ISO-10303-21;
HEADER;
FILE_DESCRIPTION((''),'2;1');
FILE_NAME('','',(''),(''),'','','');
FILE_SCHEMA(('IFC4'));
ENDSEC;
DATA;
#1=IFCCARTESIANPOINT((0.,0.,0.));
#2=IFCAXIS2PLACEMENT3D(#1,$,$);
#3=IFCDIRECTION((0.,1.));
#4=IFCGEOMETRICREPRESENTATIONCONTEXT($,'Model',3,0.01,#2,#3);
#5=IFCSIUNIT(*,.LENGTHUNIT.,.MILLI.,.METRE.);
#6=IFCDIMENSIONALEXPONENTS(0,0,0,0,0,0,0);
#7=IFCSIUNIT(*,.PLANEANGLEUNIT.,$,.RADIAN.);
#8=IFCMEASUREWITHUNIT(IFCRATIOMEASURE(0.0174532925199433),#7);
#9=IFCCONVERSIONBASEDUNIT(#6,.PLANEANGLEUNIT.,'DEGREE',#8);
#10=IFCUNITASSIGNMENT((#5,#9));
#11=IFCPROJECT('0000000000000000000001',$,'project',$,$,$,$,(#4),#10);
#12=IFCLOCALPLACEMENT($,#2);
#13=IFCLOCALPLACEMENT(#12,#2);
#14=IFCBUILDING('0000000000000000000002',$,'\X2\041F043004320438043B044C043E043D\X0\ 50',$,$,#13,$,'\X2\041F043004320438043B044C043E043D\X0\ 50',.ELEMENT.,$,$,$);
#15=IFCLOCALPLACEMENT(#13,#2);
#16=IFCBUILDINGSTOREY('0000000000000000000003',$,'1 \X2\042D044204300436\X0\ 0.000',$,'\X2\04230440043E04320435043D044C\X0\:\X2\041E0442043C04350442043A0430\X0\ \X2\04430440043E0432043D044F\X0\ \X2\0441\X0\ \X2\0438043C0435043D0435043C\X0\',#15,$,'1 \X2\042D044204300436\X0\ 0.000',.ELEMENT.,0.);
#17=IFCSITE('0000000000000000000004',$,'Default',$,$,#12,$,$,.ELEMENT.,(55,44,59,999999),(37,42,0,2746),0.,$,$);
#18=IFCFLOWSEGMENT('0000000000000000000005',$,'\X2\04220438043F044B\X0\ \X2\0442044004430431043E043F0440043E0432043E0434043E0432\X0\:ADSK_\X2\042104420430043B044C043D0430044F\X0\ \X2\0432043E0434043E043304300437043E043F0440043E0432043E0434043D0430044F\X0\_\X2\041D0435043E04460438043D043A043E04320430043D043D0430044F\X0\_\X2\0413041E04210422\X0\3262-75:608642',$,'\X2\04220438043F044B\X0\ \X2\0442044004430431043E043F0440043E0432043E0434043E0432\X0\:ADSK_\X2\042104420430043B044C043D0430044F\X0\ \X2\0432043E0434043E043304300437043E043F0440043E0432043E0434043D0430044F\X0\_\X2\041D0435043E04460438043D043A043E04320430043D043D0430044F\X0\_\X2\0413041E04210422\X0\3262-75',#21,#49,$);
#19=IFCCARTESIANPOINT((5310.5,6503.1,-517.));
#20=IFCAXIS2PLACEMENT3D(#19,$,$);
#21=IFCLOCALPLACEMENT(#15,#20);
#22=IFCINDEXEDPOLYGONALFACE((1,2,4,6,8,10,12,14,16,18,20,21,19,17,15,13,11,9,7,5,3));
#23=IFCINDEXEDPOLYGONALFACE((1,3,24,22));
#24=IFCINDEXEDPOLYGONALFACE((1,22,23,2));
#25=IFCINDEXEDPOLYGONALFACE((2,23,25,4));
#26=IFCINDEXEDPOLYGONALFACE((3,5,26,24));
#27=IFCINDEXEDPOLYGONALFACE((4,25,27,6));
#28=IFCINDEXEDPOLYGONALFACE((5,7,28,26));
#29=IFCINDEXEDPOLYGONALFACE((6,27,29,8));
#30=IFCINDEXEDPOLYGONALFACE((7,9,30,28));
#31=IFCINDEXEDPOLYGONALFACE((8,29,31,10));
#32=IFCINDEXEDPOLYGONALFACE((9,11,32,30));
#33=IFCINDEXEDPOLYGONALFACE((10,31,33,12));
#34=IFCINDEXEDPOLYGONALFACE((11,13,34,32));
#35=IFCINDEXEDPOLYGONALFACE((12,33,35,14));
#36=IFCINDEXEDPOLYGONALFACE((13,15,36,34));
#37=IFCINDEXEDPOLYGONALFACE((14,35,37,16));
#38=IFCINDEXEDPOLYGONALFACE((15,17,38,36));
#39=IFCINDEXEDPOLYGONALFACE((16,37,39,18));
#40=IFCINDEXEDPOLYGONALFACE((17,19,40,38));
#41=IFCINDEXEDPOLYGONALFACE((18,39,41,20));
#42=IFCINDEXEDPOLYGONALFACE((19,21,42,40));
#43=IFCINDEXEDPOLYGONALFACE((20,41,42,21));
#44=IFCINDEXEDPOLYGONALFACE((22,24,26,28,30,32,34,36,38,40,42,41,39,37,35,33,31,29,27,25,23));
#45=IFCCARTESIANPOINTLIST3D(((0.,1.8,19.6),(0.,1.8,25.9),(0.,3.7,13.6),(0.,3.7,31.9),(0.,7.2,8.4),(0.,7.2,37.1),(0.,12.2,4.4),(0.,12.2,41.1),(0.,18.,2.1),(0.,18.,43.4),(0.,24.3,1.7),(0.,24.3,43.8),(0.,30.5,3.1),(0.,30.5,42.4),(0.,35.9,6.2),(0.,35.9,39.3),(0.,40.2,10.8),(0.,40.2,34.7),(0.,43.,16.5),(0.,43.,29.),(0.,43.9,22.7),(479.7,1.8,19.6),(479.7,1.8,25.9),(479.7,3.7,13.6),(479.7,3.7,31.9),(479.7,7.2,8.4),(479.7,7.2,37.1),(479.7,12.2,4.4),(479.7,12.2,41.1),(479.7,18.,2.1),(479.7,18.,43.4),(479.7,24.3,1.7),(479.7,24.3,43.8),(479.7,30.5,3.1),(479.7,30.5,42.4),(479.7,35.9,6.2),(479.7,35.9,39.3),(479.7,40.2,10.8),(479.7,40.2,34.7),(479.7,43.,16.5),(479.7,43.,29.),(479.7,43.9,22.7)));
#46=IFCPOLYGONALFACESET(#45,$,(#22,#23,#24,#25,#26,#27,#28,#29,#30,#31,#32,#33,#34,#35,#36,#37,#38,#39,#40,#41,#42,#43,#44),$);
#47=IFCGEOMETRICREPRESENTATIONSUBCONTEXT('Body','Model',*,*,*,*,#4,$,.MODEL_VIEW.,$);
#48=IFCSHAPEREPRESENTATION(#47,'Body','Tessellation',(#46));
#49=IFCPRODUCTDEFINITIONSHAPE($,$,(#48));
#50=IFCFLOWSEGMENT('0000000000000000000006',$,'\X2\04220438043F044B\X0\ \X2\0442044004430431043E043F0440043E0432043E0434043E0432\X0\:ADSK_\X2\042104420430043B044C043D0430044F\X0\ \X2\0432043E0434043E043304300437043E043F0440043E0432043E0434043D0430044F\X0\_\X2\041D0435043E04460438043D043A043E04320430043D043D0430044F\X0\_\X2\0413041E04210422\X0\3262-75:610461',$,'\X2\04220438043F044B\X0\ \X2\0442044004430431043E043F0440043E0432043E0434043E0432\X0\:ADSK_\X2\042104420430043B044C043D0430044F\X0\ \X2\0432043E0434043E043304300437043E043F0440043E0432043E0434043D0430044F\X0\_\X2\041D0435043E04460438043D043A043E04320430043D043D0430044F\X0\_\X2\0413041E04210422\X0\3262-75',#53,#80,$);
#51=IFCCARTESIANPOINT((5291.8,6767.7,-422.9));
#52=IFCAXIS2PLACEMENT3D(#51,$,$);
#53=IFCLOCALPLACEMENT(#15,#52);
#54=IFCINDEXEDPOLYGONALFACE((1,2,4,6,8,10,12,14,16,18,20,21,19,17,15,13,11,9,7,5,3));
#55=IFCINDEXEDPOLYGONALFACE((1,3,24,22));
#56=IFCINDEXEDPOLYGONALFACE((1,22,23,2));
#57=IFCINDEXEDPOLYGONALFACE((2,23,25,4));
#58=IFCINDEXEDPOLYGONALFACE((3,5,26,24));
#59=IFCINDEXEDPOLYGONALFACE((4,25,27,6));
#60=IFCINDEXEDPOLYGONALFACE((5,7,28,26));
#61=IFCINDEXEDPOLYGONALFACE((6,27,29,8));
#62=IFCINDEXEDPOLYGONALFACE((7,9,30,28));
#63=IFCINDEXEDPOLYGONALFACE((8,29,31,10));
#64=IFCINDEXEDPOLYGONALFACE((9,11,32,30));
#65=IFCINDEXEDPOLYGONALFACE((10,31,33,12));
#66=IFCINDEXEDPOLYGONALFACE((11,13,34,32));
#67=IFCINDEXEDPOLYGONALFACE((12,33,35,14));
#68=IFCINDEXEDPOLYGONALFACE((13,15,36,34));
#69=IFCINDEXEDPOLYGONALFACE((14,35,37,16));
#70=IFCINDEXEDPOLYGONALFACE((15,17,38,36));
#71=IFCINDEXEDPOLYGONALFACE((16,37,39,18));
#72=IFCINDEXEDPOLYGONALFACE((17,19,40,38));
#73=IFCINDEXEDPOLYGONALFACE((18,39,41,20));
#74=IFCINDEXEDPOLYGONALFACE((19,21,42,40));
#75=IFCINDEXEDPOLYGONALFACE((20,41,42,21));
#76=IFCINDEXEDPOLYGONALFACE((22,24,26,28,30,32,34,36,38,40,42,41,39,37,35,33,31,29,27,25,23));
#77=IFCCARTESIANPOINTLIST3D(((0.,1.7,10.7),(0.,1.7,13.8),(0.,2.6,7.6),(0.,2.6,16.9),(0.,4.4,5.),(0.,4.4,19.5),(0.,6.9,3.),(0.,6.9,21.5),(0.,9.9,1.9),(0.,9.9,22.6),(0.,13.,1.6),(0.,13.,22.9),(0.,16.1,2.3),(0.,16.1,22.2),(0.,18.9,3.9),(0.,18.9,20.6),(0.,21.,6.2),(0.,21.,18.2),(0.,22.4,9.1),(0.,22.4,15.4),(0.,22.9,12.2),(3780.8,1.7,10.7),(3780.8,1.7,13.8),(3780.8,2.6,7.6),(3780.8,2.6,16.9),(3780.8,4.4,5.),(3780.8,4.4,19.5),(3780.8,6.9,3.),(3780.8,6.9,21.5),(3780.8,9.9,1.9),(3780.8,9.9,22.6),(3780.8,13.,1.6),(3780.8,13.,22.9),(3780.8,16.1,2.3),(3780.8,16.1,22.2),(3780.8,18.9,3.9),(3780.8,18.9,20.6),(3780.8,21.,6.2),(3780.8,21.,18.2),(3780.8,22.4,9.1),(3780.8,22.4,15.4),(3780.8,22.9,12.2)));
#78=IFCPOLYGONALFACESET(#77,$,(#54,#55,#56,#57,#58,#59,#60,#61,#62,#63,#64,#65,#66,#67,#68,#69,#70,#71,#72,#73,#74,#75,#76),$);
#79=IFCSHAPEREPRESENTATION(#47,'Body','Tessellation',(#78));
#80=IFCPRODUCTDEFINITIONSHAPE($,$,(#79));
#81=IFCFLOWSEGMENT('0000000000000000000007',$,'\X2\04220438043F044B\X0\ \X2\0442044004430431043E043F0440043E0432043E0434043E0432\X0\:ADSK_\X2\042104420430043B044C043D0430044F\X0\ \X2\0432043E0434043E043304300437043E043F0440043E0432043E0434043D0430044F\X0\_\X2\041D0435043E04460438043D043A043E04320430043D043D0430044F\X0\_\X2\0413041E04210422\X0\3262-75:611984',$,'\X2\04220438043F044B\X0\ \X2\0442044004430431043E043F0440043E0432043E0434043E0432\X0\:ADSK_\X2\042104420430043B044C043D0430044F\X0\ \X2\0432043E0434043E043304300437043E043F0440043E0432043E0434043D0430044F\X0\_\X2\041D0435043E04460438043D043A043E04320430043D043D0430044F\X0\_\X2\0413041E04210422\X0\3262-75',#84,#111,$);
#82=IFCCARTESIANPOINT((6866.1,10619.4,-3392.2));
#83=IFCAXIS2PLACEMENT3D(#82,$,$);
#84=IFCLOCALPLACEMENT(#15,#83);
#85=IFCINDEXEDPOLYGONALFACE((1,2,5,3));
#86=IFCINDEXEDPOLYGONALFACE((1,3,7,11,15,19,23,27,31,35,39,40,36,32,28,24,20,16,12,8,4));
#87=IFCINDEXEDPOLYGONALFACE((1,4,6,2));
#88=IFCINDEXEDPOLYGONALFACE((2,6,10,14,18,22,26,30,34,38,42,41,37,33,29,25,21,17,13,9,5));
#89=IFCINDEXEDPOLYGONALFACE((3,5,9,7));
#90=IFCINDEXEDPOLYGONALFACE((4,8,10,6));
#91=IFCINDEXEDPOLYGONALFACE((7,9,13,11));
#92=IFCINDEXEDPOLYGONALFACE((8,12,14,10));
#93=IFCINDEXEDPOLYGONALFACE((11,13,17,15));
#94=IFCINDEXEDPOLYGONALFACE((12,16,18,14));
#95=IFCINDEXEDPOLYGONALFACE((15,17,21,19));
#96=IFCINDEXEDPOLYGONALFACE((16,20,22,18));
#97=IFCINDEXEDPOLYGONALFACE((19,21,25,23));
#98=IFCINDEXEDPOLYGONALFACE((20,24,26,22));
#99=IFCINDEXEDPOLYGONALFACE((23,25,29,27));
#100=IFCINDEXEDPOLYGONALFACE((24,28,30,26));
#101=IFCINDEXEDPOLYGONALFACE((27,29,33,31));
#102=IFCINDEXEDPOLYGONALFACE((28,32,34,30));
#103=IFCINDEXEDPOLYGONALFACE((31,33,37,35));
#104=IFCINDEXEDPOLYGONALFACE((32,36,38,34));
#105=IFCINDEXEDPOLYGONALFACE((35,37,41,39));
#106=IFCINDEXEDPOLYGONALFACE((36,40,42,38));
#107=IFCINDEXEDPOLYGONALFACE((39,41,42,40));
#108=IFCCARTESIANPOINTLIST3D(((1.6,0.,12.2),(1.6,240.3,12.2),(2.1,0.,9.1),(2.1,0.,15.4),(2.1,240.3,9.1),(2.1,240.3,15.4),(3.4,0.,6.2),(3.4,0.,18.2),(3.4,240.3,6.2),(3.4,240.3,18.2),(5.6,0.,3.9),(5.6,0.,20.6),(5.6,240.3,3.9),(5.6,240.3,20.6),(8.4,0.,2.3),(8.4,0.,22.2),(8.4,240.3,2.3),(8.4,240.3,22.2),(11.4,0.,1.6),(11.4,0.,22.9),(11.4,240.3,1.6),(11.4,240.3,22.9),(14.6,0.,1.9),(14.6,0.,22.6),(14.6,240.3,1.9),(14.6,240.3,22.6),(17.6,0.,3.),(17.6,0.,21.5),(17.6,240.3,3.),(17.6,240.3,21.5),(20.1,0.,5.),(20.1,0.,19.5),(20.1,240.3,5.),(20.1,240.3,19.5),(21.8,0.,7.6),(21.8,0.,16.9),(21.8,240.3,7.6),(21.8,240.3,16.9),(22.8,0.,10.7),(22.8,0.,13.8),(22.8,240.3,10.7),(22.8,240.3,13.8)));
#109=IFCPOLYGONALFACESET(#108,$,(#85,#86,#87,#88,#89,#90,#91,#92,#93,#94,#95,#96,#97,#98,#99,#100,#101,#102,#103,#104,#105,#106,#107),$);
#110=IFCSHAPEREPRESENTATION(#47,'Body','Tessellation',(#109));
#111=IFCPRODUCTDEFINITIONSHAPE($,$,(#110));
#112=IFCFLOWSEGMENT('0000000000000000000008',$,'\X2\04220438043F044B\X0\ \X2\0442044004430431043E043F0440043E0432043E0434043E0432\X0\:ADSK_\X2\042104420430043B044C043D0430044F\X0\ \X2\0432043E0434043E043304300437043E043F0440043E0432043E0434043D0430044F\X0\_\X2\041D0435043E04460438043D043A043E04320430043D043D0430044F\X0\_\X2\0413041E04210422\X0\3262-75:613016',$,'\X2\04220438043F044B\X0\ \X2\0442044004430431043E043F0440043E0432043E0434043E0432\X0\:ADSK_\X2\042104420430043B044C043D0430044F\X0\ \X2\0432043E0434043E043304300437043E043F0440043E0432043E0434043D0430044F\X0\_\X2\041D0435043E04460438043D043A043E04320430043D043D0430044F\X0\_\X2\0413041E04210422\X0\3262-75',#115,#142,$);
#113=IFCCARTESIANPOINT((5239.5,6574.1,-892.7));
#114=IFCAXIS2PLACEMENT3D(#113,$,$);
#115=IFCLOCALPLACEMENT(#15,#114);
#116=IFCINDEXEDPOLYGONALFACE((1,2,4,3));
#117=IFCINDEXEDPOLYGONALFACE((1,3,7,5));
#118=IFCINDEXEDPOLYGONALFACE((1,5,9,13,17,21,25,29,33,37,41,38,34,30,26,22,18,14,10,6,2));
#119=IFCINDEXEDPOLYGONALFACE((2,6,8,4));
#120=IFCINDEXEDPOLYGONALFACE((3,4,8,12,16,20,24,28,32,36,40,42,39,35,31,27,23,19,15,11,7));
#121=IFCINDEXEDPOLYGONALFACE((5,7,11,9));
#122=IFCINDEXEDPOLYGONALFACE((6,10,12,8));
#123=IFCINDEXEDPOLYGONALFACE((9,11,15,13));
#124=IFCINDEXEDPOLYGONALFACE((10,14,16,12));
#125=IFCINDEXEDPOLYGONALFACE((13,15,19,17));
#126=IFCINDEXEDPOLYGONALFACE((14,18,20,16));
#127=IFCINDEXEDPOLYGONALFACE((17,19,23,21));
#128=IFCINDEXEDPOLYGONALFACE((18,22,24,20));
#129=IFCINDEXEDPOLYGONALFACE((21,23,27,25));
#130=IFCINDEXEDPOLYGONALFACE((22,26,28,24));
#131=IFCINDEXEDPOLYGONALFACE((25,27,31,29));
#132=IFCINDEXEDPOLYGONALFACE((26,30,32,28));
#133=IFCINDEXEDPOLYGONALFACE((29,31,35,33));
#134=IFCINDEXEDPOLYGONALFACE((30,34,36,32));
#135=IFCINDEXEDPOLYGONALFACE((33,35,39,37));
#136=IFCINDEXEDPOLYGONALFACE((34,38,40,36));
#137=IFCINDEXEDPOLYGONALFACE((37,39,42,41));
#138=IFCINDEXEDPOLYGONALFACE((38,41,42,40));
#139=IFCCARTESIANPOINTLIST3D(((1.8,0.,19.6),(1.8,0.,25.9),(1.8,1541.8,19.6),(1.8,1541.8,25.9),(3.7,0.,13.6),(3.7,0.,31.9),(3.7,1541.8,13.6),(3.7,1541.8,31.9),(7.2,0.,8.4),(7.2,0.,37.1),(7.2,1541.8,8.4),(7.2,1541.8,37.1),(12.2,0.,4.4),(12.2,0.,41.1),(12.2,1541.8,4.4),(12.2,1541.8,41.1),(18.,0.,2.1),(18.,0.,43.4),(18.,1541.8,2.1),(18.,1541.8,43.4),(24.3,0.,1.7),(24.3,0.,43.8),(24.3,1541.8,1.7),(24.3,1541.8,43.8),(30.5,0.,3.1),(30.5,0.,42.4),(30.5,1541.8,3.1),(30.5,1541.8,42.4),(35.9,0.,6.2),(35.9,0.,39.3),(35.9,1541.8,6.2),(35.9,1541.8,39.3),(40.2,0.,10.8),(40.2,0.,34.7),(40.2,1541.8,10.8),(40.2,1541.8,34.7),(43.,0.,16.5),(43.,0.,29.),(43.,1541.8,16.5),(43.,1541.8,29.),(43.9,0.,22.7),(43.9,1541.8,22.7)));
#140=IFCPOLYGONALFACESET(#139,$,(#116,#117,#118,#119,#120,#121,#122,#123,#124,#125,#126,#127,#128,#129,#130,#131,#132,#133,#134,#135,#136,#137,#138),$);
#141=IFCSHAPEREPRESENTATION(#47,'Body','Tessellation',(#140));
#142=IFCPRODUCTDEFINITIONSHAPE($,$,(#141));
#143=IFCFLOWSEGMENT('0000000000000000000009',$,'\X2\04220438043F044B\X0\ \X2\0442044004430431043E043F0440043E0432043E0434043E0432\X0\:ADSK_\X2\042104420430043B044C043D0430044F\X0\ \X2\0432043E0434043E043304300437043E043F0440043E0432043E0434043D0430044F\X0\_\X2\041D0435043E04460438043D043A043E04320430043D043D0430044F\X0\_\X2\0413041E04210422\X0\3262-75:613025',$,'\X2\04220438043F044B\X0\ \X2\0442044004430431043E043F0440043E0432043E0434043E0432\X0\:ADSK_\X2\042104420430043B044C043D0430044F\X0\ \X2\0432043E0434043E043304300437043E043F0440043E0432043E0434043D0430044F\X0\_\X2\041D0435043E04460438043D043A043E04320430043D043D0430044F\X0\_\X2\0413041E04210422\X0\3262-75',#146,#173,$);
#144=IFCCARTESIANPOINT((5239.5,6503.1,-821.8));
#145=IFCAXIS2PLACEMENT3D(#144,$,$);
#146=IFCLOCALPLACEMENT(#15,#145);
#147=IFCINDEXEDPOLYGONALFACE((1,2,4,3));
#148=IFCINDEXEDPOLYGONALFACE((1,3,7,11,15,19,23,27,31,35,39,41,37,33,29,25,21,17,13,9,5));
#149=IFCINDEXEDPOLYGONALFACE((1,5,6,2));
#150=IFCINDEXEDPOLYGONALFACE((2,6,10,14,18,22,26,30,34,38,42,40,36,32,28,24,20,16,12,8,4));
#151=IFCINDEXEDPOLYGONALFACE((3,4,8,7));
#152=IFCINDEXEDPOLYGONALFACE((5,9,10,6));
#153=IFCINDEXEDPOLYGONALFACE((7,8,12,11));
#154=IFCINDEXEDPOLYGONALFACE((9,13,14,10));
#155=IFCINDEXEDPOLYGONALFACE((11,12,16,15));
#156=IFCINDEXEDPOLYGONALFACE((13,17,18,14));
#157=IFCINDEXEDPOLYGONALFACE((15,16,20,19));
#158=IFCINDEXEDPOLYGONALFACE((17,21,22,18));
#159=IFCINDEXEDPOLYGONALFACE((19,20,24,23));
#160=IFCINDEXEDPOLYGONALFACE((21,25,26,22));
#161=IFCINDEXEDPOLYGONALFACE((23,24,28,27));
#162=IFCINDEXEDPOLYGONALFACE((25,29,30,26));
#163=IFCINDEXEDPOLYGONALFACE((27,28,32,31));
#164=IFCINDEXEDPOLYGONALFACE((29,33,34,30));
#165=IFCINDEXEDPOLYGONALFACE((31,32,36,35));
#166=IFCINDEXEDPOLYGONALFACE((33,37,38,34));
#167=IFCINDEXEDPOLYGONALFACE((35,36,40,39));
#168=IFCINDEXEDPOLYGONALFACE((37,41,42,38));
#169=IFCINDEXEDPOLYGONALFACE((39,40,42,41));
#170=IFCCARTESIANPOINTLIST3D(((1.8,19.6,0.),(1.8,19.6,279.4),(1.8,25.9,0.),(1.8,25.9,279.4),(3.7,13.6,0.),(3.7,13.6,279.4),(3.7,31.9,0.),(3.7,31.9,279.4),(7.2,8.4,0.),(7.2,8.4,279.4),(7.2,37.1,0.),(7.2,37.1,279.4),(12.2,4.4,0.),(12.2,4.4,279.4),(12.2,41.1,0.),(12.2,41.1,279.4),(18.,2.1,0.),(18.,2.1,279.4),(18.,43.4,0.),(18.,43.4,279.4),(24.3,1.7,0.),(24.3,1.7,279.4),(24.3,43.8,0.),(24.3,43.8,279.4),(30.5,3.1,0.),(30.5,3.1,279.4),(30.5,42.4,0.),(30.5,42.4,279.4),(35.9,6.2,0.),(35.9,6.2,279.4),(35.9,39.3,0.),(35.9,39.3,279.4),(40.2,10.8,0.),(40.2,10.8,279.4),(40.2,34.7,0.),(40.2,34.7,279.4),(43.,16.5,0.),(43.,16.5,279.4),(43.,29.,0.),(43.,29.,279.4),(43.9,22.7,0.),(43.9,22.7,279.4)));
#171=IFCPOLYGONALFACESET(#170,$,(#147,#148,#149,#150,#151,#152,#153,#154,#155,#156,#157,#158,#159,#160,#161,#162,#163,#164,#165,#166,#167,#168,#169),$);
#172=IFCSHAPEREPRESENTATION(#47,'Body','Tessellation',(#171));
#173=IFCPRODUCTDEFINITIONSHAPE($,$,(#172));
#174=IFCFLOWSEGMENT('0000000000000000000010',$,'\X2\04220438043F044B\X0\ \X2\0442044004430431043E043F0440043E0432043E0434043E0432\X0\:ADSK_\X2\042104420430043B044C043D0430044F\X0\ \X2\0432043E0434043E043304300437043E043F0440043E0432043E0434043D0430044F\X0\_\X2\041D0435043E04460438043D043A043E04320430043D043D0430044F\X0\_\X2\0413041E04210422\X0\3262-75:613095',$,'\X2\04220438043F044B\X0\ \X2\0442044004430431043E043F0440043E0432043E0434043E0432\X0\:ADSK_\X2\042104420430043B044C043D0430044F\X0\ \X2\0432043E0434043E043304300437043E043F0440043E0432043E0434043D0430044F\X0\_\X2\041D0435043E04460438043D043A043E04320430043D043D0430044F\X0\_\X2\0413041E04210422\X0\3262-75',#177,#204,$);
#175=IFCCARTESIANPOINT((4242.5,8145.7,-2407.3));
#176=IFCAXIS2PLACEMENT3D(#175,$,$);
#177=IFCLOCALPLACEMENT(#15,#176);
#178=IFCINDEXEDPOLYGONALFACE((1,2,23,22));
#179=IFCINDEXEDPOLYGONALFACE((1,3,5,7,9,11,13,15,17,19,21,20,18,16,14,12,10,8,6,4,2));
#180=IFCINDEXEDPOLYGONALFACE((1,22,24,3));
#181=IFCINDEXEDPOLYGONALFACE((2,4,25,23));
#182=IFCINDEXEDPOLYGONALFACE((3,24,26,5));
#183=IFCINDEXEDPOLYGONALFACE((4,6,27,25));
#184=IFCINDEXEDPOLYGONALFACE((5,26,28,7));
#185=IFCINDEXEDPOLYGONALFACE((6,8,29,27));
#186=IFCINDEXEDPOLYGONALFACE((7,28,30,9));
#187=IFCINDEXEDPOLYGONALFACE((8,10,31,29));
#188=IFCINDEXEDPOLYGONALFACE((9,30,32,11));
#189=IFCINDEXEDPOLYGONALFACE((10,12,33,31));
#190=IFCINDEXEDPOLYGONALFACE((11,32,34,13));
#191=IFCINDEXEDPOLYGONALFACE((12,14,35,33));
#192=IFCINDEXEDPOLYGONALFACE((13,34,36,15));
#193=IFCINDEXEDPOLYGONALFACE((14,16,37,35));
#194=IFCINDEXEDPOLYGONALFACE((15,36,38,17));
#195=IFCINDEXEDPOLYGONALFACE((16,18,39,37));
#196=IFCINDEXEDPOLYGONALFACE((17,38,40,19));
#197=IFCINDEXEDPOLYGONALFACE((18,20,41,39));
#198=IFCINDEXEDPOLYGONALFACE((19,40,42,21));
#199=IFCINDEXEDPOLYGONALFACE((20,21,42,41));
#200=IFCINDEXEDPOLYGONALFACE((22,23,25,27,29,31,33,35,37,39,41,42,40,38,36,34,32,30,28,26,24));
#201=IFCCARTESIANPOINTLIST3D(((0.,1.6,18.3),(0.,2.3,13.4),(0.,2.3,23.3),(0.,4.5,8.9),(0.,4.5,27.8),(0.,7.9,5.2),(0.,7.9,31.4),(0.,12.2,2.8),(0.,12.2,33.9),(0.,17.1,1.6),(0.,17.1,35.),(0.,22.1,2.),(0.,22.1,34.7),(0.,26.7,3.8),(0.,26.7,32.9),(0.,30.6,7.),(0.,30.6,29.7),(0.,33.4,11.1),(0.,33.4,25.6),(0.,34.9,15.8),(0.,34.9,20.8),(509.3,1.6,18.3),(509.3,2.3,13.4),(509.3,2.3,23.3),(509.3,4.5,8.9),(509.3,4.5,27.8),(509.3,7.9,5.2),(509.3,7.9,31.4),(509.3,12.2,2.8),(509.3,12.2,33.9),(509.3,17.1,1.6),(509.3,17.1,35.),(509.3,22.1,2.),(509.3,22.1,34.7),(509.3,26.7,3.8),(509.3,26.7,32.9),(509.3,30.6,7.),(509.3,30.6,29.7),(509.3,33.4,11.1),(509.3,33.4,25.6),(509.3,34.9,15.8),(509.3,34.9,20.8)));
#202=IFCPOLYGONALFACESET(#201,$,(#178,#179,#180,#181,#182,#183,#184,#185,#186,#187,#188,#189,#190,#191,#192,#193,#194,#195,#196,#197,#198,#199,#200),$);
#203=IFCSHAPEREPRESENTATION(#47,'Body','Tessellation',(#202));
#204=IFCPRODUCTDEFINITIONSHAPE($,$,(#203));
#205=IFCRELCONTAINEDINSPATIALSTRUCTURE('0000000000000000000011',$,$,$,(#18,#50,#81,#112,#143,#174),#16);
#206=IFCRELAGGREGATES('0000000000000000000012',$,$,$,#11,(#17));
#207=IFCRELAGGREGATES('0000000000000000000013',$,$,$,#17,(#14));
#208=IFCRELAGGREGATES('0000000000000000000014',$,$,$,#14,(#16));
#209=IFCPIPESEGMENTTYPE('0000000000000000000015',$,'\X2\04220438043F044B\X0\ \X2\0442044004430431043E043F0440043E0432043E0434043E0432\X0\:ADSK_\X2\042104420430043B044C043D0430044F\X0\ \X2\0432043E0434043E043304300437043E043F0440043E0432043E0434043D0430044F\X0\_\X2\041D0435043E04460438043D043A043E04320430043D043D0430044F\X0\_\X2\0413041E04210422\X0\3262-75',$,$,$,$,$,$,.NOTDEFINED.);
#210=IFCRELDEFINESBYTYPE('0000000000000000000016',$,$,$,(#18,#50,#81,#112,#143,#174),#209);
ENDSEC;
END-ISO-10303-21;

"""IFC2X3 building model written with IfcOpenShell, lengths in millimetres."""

from ifc_helpers import new_model, entity, si_unit, converted_unit, direction, frame, frame_2d, origin, origin_2d_with_axis, place, context, subcontext, project, spatial, circle, extrude, type_object, element, save


model = new_model("IFC2X3")

# Units and contexts
model_context = context("Model", 3, precision=0.01, world=origin(), true_north=direction((0.0, 1.0)))
body_context = subcontext(model_context, "Body", "Model", "MODEL_VIEW")
ifc_project = project(units=[si_unit("LENGTHUNIT", "METRE", prefix="MILLI"), converted_unit("PLANEANGLEUNIT", "DEGREE", entity("IfcRatioMeasure", 0.0174532925199433), si_unit("PLANEANGLEUNIT", "RADIAN"), dimensions=[0, 0, 0, 0, 0, 0, 0])], contexts=[model_context])

# Site, building, storey
site_placement = place(None, origin())
site = spatial("IfcSite", under=ifc_project, at=site_placement, Name="Default", CompositionType="ELEMENT", RefLatitude=(55, 44, 59, 999999), RefLongitude=(37, 42, 0, 2746), RefElevation=0.0)
building_placement = place(site_placement, origin())
building = spatial("IfcBuilding", under=site, at=building_placement, Name="Павильон 50", LongName="Павильон 50", CompositionType="ELEMENT")
storey_placement = place(building_placement, origin())
storey = spatial("IfcBuildingStorey", under=building, at=storey_placement, Name="1 Этаж 0.000", ObjectType="Уровень:Отметка уровня с именем", LongName="1 Этаж 0.000", CompositionType="ELEMENT", Elevation=0.0)

# Flow segments
pipe_segment_type = type_object("IfcPipeSegmentType", Name="Типы трубопроводов:ADSK_Стальная водогазопроводная_Неоцинкованная_ГОСТ3262-75", PredefinedType="NOTDEFINED")
flow_segment_1_placement = place(storey_placement, frame((5310.5, 6503.1, -517.0)))
element("IfcFlowSegment", 1, at=flow_segment_1_placement, inside=storey, type_object=pipe_segment_type, Name="Типы трубопроводов:ADSK_Стальная водогазопроводная_Неоцинкованная_ГОСТ3262-75:608642", ObjectType="Типы трубопроводов:ADSK_Стальная водогазопроводная_Неоцинкованная_ГОСТ3262-75", context=body_context, shape_type="SweptSolid", body=[
    extrude(circle(Radius=21.1, at=frame_2d((0.0, 0.0), x_axis=(1.0, 0.0))), frame((0.0, 22.7, 22.7), z_axis=(1.0, 0.0, 0.0), x_axis=(0.0, 1.0, 0.0)), (0.0, 0.0, 1.0), 479.7),
])
flow_segment_2_placement = place(storey_placement, frame((5291.8, 6767.7, -422.9)))
element("IfcFlowSegment", 2, at=flow_segment_2_placement, inside=storey, type_object=pipe_segment_type, Name="Типы трубопроводов:ADSK_Стальная водогазопроводная_Неоцинкованная_ГОСТ3262-75:610461", ObjectType="Типы трубопроводов:ADSK_Стальная водогазопроводная_Неоцинкованная_ГОСТ3262-75", context=body_context, shape_type="SweptSolid", body=[
    extrude(circle(Radius=10.7, at=frame_2d((0.0, 0.0), x_axis=(1.0, 0.0))), frame((0.0, 12.2, 12.2), z_axis=(1.0, 0.0, 0.0), x_axis=(0.0, 1.0, 0.0)), (0.0, 0.0, 1.0), 3780.8),
])
flow_segment_3_placement = place(storey_placement, frame((6866.1, 10619.4, -3392.2)))
element("IfcFlowSegment", 3, at=flow_segment_3_placement, inside=storey, type_object=pipe_segment_type, Name="Типы трубопроводов:ADSK_Стальная водогазопроводная_Неоцинкованная_ГОСТ3262-75:611984", ObjectType="Типы трубопроводов:ADSK_Стальная водогазопроводная_Неоцинкованная_ГОСТ3262-75", context=body_context, shape_type="SweptSolid", body=[
    extrude(circle(Radius=10.7, at=origin_2d_with_axis()), frame((12.2, 0.0, 12.2), z_axis=(0.0, 1.0, 0.0), x_axis=(-1.0, 0.0, 0.0)), (0.0, 0.0, 1.0), 240.3),
])
flow_segment_4_placement = place(storey_placement, frame((5239.5, 6574.1, -892.7)))
element("IfcFlowSegment", 4, at=flow_segment_4_placement, inside=storey, type_object=pipe_segment_type, Name="Типы трубопроводов:ADSK_Стальная водогазопроводная_Неоцинкованная_ГОСТ3262-75:613016", ObjectType="Типы трубопроводов:ADSK_Стальная водогазопроводная_Неоцинкованная_ГОСТ3262-75", context=body_context, shape_type="SweptSolid", body=[
    extrude(circle(Radius=21.1, at=frame_2d((0.0, 0.0), x_axis=(1.0, 0.0))), frame((22.7, 0.0, 22.7), z_axis=(0.0, 1.0, 0.0), x_axis=(1.0, 0.0, 0.0)), (0.0, 0.0, 1.0), 1541.8),
])
flow_segment_5_placement = place(storey_placement, frame((5239.5, 6503.1, -821.8)))
element("IfcFlowSegment", 5, at=flow_segment_5_placement, inside=storey, type_object=pipe_segment_type, Name="Типы трубопроводов:ADSK_Стальная водогазопроводная_Неоцинкованная_ГОСТ3262-75:613025", ObjectType="Типы трубопроводов:ADSK_Стальная водогазопроводная_Неоцинкованная_ГОСТ3262-75", context=body_context, shape_type="SweptSolid", body=[
    extrude(circle(Radius=21.1, at=origin_2d_with_axis()), frame((22.7, 22.7, 0.0)), (0.0, 0.0, 1.0), 279.4),
])
flow_segment_6_placement = place(storey_placement, frame((4242.5, 8145.7, -2407.3)))
element("IfcFlowSegment", 6, at=flow_segment_6_placement, inside=storey, type_object=pipe_segment_type, Name="Типы трубопроводов:ADSK_Стальная водогазопроводная_Неоцинкованная_ГОСТ3262-75:613095", ObjectType="Типы трубопроводов:ADSK_Стальная водогазопроводная_Неоцинкованная_ГОСТ3262-75", context=body_context, shape_type="SweptSolid", body=[
    extrude(circle(Radius=16.8, at=origin_2d_with_axis()), frame((0.0, 18.3, 18.3), z_axis=(1.0, 0.0, 0.0), x_axis=(0.0, -1.0, 0.0)), (0.0, 0.0, 1.0), 509.3),
])

save(model, "model.ifc")
